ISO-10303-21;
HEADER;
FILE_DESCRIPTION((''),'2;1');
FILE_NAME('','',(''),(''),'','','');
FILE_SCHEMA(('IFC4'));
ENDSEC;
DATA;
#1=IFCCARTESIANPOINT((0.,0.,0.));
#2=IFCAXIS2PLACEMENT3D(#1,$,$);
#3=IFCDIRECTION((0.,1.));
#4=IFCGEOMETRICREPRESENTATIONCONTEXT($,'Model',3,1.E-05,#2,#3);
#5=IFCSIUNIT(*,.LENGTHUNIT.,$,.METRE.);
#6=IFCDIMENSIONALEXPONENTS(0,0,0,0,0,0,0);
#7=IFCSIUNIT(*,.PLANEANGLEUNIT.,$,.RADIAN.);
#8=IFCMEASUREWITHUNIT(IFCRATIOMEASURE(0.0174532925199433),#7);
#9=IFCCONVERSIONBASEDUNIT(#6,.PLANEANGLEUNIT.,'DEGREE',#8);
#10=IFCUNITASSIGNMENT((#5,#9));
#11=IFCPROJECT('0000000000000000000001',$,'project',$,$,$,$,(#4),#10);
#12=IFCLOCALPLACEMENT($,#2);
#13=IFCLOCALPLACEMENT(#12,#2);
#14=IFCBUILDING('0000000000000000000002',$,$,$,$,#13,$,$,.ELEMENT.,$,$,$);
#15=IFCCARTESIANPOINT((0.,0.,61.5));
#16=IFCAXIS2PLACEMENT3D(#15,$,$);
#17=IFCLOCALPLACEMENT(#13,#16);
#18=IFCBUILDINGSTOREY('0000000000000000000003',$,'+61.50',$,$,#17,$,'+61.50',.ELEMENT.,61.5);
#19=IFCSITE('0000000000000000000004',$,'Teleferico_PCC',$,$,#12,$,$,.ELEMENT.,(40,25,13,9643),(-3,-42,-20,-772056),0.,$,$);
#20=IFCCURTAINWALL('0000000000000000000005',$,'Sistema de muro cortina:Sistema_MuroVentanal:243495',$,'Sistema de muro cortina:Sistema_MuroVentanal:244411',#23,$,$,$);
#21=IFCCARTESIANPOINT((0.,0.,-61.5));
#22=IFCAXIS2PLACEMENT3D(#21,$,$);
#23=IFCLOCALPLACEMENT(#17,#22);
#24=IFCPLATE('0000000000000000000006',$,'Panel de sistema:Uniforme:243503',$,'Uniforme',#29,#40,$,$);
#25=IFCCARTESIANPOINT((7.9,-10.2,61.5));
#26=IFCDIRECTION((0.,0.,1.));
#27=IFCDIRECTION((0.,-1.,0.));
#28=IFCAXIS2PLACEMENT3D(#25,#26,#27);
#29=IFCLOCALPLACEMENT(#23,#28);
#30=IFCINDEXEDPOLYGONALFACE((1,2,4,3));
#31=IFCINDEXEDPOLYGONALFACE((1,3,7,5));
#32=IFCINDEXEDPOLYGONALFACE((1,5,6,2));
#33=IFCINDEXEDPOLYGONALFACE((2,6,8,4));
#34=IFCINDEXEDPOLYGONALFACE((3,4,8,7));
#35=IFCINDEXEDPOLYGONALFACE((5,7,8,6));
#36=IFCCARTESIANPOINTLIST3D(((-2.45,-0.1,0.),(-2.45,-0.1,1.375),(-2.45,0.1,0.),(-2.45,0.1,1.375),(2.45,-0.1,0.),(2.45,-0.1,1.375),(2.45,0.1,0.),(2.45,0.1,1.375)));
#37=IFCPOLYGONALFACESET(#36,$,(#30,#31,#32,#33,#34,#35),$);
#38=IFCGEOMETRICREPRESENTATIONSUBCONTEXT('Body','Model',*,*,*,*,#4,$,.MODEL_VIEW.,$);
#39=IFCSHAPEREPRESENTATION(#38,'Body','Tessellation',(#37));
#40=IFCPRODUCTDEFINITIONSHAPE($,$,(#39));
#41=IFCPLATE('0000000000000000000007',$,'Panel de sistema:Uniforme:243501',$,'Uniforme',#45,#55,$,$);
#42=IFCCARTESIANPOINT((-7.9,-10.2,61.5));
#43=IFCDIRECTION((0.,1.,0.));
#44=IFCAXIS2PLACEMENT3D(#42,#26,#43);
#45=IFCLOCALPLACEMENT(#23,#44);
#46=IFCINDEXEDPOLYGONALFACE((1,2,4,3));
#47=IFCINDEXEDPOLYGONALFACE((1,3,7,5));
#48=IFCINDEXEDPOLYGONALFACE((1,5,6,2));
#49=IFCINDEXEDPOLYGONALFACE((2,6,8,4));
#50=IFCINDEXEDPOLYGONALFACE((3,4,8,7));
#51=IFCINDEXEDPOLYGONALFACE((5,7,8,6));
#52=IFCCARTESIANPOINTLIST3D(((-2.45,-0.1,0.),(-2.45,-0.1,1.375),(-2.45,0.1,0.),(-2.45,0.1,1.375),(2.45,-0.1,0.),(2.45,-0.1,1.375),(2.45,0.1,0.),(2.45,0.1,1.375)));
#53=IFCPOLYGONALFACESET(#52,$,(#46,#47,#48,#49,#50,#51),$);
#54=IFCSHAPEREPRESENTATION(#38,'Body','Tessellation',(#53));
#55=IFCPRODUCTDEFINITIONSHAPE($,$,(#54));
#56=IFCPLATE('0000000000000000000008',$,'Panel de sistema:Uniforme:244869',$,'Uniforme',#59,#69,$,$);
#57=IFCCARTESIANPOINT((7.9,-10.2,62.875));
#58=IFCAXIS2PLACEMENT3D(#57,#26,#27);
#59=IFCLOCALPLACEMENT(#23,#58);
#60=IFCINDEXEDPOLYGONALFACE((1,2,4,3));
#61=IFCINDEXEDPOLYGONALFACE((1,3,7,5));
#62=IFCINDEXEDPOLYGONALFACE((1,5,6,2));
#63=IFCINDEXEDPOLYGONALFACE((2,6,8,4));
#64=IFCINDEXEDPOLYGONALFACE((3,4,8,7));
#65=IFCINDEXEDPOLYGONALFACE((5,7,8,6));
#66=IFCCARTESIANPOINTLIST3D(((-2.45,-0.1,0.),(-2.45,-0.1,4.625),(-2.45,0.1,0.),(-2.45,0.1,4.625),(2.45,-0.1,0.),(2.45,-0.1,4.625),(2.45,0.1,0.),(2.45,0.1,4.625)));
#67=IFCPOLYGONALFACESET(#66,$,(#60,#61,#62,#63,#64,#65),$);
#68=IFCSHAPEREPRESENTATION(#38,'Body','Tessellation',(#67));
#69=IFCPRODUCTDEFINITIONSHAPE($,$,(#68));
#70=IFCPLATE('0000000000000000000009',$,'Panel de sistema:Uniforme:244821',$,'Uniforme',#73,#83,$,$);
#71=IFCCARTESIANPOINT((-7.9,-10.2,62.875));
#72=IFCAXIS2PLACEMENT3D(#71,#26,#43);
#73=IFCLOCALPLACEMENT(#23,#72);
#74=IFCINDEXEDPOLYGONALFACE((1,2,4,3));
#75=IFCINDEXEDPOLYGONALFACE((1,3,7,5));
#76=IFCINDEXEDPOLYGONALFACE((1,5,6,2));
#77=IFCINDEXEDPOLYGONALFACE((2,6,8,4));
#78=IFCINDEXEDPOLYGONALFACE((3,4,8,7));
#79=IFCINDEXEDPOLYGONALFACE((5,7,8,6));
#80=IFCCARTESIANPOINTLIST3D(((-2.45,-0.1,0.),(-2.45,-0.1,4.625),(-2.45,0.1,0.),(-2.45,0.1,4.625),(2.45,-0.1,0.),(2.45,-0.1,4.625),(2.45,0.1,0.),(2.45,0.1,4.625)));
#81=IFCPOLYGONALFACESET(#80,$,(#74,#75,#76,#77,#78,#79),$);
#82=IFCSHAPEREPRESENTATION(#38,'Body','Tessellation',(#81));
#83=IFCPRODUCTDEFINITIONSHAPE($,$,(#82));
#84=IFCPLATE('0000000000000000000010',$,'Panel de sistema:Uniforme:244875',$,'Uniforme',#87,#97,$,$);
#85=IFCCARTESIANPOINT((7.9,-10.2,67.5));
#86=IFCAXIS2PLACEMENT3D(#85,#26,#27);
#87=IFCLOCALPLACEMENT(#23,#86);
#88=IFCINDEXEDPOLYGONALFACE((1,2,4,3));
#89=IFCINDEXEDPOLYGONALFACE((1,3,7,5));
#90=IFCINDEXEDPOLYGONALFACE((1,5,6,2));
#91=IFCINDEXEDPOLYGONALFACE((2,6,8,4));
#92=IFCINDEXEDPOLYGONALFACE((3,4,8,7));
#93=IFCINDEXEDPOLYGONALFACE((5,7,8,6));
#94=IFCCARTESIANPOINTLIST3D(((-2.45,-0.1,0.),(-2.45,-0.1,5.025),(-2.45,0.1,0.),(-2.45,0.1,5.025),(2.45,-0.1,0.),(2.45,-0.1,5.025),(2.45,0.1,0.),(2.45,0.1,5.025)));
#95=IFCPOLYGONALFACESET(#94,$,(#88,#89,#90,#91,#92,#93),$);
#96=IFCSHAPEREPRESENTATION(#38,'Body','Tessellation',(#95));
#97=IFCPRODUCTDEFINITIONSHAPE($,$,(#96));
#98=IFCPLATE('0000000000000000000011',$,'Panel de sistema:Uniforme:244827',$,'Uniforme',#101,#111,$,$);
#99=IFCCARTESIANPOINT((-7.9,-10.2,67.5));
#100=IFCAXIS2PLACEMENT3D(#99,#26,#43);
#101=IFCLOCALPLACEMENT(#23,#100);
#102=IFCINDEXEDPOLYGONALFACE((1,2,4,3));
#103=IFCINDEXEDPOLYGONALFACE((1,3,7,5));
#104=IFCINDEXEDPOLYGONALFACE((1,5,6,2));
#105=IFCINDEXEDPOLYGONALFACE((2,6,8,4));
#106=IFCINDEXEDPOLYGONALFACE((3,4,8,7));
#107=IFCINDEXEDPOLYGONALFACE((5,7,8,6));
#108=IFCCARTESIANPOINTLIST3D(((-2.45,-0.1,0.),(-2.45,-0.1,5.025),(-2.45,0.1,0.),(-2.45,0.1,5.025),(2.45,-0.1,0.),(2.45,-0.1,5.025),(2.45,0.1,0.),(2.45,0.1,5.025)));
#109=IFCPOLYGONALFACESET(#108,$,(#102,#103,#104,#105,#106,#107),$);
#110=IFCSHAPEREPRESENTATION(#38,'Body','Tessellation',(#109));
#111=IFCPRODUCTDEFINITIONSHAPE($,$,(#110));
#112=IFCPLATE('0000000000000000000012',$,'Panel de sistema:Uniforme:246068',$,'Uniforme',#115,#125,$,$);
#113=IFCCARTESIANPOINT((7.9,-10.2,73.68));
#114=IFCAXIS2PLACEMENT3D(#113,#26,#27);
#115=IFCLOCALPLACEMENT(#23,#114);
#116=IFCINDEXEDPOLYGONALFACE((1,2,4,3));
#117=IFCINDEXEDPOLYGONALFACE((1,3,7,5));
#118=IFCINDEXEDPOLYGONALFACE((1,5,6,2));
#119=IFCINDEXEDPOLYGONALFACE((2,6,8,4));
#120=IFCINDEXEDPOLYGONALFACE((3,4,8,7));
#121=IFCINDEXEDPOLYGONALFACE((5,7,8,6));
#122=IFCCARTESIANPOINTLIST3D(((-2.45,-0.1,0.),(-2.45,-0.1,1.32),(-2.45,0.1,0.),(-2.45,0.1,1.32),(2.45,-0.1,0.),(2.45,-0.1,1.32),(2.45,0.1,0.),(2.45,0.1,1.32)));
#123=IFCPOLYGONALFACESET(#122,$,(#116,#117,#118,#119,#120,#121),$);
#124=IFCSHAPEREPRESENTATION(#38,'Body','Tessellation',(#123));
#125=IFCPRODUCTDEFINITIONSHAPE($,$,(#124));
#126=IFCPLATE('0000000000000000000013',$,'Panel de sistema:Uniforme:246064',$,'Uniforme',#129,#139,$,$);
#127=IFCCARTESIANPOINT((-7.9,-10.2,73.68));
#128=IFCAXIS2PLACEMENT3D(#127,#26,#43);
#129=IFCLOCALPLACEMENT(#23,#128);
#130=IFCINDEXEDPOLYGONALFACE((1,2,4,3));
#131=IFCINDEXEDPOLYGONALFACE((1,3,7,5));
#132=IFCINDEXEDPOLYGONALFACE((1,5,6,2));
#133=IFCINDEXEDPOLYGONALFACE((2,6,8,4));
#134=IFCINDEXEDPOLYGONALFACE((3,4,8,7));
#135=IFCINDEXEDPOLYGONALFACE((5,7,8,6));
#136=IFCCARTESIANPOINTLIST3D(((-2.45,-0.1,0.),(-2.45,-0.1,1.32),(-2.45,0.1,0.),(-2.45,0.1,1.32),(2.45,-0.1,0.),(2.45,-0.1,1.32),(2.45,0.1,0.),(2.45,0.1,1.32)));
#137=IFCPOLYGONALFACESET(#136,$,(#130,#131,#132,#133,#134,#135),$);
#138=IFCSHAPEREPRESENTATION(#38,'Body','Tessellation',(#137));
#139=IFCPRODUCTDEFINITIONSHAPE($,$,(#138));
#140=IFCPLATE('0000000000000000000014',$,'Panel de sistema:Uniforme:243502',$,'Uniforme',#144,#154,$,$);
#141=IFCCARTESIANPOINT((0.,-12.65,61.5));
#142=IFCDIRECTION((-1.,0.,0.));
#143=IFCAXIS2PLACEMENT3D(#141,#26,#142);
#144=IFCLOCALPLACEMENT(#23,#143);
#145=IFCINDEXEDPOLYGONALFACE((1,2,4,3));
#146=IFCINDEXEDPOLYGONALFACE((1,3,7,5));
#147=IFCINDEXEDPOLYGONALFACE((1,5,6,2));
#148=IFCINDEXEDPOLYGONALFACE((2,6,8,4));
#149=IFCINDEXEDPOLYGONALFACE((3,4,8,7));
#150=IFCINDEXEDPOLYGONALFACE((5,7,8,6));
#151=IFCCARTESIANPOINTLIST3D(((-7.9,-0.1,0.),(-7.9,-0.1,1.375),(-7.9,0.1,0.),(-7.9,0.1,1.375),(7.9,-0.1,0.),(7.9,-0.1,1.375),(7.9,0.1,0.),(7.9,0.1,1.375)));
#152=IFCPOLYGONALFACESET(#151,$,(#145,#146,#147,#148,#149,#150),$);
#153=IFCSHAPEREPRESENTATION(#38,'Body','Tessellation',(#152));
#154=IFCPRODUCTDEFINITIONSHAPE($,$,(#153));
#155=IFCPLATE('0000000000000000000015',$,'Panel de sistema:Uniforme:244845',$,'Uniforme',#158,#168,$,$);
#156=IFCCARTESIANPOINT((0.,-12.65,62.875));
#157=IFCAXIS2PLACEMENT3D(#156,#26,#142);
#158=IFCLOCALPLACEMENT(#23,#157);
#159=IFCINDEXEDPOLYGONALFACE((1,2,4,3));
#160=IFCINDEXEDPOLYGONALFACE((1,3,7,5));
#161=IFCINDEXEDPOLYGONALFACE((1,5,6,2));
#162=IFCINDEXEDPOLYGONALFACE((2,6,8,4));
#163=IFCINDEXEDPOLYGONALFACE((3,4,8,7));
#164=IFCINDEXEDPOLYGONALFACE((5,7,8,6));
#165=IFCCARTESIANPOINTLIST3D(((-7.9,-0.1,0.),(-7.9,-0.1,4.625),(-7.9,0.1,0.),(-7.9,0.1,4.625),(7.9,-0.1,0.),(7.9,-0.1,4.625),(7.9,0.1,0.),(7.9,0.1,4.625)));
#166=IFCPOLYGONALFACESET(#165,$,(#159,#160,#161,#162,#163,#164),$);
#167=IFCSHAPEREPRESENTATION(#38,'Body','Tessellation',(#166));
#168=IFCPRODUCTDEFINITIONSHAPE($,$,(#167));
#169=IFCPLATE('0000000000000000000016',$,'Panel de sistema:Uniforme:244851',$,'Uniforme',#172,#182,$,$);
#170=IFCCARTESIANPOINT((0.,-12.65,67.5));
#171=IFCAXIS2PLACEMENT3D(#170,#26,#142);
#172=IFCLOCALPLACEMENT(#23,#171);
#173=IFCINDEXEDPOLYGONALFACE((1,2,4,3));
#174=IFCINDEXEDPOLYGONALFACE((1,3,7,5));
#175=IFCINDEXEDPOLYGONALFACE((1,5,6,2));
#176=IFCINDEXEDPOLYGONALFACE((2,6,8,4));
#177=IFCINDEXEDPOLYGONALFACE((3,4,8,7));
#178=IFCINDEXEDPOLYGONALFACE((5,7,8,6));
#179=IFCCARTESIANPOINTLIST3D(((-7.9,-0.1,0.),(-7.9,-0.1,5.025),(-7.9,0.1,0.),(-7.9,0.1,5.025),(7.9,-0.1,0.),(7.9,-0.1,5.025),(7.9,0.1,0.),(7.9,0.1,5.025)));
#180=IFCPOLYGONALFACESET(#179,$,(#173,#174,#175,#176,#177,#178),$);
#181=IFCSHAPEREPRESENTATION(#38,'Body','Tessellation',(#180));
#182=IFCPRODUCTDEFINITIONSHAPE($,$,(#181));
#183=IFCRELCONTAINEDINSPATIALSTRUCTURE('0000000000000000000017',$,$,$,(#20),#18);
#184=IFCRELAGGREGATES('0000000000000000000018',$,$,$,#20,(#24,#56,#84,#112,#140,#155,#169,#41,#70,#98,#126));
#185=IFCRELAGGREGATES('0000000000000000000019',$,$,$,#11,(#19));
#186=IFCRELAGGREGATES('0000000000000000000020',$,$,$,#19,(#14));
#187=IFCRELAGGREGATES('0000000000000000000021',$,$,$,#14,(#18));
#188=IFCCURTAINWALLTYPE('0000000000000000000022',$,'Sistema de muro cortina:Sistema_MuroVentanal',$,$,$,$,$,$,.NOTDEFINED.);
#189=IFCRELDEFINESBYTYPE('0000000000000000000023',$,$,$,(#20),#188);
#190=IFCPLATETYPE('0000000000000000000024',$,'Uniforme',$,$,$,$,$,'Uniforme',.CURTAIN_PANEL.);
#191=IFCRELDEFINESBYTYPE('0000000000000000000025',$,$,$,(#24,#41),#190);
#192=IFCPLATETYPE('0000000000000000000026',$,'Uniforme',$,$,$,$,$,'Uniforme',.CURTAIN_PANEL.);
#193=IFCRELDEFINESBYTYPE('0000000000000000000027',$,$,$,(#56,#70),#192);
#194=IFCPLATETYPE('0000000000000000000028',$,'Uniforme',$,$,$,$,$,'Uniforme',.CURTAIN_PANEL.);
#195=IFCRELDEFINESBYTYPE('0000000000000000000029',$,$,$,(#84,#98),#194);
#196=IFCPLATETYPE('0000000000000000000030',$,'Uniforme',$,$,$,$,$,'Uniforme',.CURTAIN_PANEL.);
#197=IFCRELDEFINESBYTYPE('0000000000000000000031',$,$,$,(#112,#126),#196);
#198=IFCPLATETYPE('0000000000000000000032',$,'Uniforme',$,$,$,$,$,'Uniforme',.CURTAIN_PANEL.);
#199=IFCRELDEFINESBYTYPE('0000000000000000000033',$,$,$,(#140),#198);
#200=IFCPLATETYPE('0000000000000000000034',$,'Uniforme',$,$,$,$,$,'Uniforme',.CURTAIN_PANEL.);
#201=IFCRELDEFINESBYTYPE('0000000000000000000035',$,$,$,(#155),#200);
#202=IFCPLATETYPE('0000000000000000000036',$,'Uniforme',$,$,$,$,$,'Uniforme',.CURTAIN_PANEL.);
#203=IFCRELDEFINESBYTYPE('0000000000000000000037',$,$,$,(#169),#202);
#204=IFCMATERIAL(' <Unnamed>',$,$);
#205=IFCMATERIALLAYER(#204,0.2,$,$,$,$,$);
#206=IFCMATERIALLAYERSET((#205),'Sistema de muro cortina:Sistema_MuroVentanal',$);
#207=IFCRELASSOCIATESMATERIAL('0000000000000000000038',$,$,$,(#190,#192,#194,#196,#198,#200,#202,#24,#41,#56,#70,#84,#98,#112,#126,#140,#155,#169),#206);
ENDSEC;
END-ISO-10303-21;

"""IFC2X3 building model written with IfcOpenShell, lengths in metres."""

from ifc_helpers import new_model, entity, si_unit, converted_unit, direction, frame, origin, origin_2d_with_axis, place, context, subcontext, project, spatial, rectangle, extrude, source, transform, mapped, material, layer, layer_set, layer_usage, type_object, type_shapes, element, aggregate, save


model = new_model("IFC2X3")

# Units and contexts
model_context = context("Model", 3, precision=1e-05, world=origin(), true_north=direction((0.0, 1.0)))
body_context = subcontext(model_context, "Body", "Model", "MODEL_VIEW")
ifc_project = project(units=[si_unit("LENGTHUNIT", "METRE"), converted_unit("PLANEANGLEUNIT", "DEGREE", entity("IfcRatioMeasure", 0.0174532925199433), si_unit("PLANEANGLEUNIT", "RADIAN"), dimensions=[0, 0, 0, 0, 0, 0, 0])], contexts=[model_context])

# Site, building, storey
site_placement = place(None, origin())
site = spatial("IfcSite", under=ifc_project, at=site_placement, Name="Teleferico_PCC", CompositionType="ELEMENT", RefLatitude=(40, 25, 13, 9643), RefLongitude=(-3, -42, -20, -772056), RefElevation=0.0)
building_placement = place(site_placement, origin())
building = spatial("IfcBuilding", under=site, at=building_placement, CompositionType="ELEMENT")
storey_placement = place(building_placement, frame((0.0, 0.0, 61.5)))
storey = spatial("IfcBuildingStorey", under=building, at=storey_placement, Name="+61.50", LongName="+61.50", CompositionType="ELEMENT", Elevation=61.5)

# Curtain wall, plates
curtain_wall_type = type_object("IfcCurtainWallType", Name="Sistema de muro cortina:Sistema_MuroVentanal", PredefinedType="NOTDEFINED")
curtain_wall_placement = place(storey_placement, frame((0.0, 0.0, -61.5)))
curtain_wall = element("IfcCurtainWall", 1, at=curtain_wall_placement, inside=storey, type_object=curtain_wall_type, Name="Sistema de muro cortina:Sistema_MuroVentanal:243495", ObjectType="Sistema de muro cortina:Sistema_MuroVentanal:244411")
ifc_material = material(Name=" <Unnamed>")
ifc_layer_1 = layer(ifc_material, 0.2)
ifc_layer_set_1 = layer_set([ifc_layer_1], Name="Sistema de muro cortina:Sistema_MuroVentanal")
ifc_layer_usage_1 = layer_usage(ifc_layer_set_1, "AXIS3", "POSITIVE", 0.0)
plate_type_1 = type_object("IfcPlateType", Name="Uniforme", ElementType="Uniforme", PredefinedType="CURTAIN_PANEL", material=ifc_layer_set_1)
shared_shape_1 = source(origin(), body_context, "Body", "SweptSolid", [
    extrude(rectangle(XDim=0.2, YDim=4.9, at=origin_2d_with_axis()), frame((0.0, 0.0, 0.0), z_axis=(0.0, 0.0, 1.0), x_axis=(0.0, 1.0, 0.0)), (0.0, 0.0, 1.0), 1.375),
])
type_shapes(plate_type_1, [shared_shape_1])
plate_1_placement = place(curtain_wall_placement, frame((7.9, -10.2, 61.5), z_axis=(0.0, 0.0, 1.0), x_axis=(0.0, -1.0, 0.0)))
plate_1 = element("IfcPlate", 2, at=plate_1_placement, type_object=plate_type_1, material=ifc_layer_usage_1, Name="Panel de sistema:Uniforme:243503", ObjectType="Uniforme", context=body_context, shape_type="MappedRepresentation", body=[
    mapped(shared_shape_1, transform((0.0, 0.0, 0.0), scale=1.0)),
])
ifc_layer_usage_2 = layer_usage(ifc_layer_set_1, "AXIS3", "POSITIVE", 0.0)
plate_2_placement = place(curtain_wall_placement, frame((-7.9, -10.2, 61.5), z_axis=(0.0, 0.0, 1.0), x_axis=(0.0, 1.0, 0.0)))
plate_2 = element("IfcPlate", 3, at=plate_2_placement, type_object=plate_type_1, material=ifc_layer_usage_2, Name="Panel de sistema:Uniforme:243501", ObjectType="Uniforme", context=body_context, shape_type="MappedRepresentation", body=[
    mapped(shared_shape_1, transform((0.0, 0.0, 0.0), scale=1.0)),
])
ifc_layer_usage_3 = layer_usage(ifc_layer_set_1, "AXIS3", "POSITIVE", 0.0)
plate_type_2 = type_object("IfcPlateType", Name="Uniforme", ElementType="Uniforme", PredefinedType="CURTAIN_PANEL", material=ifc_layer_set_1)
shared_shape_2 = source(origin(), body_context, "Body", "SweptSolid", [
    extrude(rectangle(XDim=0.2, YDim=4.9, at=origin_2d_with_axis()), frame((0.0, 0.0, 0.0), z_axis=(0.0, 0.0, 1.0), x_axis=(0.0, 1.0, 0.0)), (0.0, 0.0, 1.0), 4.625),
])
type_shapes(plate_type_2, [shared_shape_2])
plate_3_placement = place(curtain_wall_placement, frame((7.9, -10.2, 62.875), z_axis=(0.0, 0.0, 1.0), x_axis=(0.0, -1.0, 0.0)))
plate_3 = element("IfcPlate", 4, at=plate_3_placement, type_object=plate_type_2, material=ifc_layer_usage_3, Name="Panel de sistema:Uniforme:244869", ObjectType="Uniforme", context=body_context, shape_type="MappedRepresentation", body=[
    mapped(shared_shape_2, transform((0.0, 0.0, 0.0), scale=1.0)),
])
ifc_layer_usage_4 = layer_usage(ifc_layer_set_1, "AXIS3", "POSITIVE", 0.0)
plate_4_placement = place(curtain_wall_placement, frame((-7.9, -10.2, 62.875), z_axis=(0.0, 0.0, 1.0), x_axis=(0.0, 1.0, 0.0)))
plate_4 = element("IfcPlate", 5, at=plate_4_placement, type_object=plate_type_2, material=ifc_layer_usage_4, Name="Panel de sistema:Uniforme:244821", ObjectType="Uniforme", context=body_context, shape_type="MappedRepresentation", body=[
    mapped(shared_shape_2, transform((0.0, 0.0, 0.0), scale=1.0)),
])
ifc_layer_usage_5 = layer_usage(ifc_layer_set_1, "AXIS3", "POSITIVE", 0.0)
plate_type_3 = type_object("IfcPlateType", Name="Uniforme", ElementType="Uniforme", PredefinedType="CURTAIN_PANEL", material=ifc_layer_set_1)
shared_shape_3 = source(origin(), body_context, "Body", "SweptSolid", [
    extrude(rectangle(XDim=0.2, YDim=4.9, at=origin_2d_with_axis()), frame((0.0, 0.0, 0.0), z_axis=(0.0, 0.0, 1.0), x_axis=(0.0, 1.0, 0.0)), (0.0, 0.0, 1.0), 5.025),
])
type_shapes(plate_type_3, [shared_shape_3])
plate_5_placement = place(curtain_wall_placement, frame((7.9, -10.2, 67.5), z_axis=(0.0, 0.0, 1.0), x_axis=(0.0, -1.0, 0.0)))
plate_5 = element("IfcPlate", 6, at=plate_5_placement, type_object=plate_type_3, material=ifc_layer_usage_5, Name="Panel de sistema:Uniforme:244875", ObjectType="Uniforme", context=body_context, shape_type="MappedRepresentation", body=[
    mapped(shared_shape_3, transform((0.0, 0.0, 0.0), scale=1.0)),
])
ifc_layer_usage_6 = layer_usage(ifc_layer_set_1, "AXIS3", "POSITIVE", 0.0)
plate_6_placement = place(curtain_wall_placement, frame((-7.9, -10.2, 67.5), z_axis=(0.0, 0.0, 1.0), x_axis=(0.0, 1.0, 0.0)))
plate_6 = element("IfcPlate", 7, at=plate_6_placement, type_object=plate_type_3, material=ifc_layer_usage_6, Name="Panel de sistema:Uniforme:244827", ObjectType="Uniforme", context=body_context, shape_type="MappedRepresentation", body=[
    mapped(shared_shape_3, transform((0.0, 0.0, 0.0), scale=1.0)),
])
ifc_layer_usage_7 = layer_usage(ifc_layer_set_1, "AXIS3", "POSITIVE", 0.0)
plate_type_4 = type_object("IfcPlateType", Name="Uniforme", ElementType="Uniforme", PredefinedType="CURTAIN_PANEL", material=ifc_layer_set_1)
shared_shape_4 = source(origin(), body_context, "Body", "SweptSolid", [
    extrude(rectangle(XDim=0.2, YDim=4.9, at=origin_2d_with_axis()), frame((0.0, 0.0, 0.0), z_axis=(0.0, 0.0, 1.0), x_axis=(0.0, 1.0, 0.0)), (0.0, 0.0, 1.0), 1.32),
])
type_shapes(plate_type_4, [shared_shape_4])
plate_7_placement = place(curtain_wall_placement, frame((7.9, -10.2, 73.68), z_axis=(0.0, 0.0, 1.0), x_axis=(0.0, -1.0, 0.0)))
plate_7 = element("IfcPlate", 8, at=plate_7_placement, type_object=plate_type_4, material=ifc_layer_usage_7, Name="Panel de sistema:Uniforme:246068", ObjectType="Uniforme", context=body_context, shape_type="MappedRepresentation", body=[
    mapped(shared_shape_4, transform((0.0, 0.0, 0.0), scale=1.0)),
])
ifc_layer_usage_8 = layer_usage(ifc_layer_set_1, "AXIS3", "POSITIVE", 0.0)
plate_8_placement = place(curtain_wall_placement, frame((-7.9, -10.2, 73.68), z_axis=(0.0, 0.0, 1.0), x_axis=(0.0, 1.0, 0.0)))
plate_8 = element("IfcPlate", 9, at=plate_8_placement, type_object=plate_type_4, material=ifc_layer_usage_8, Name="Panel de sistema:Uniforme:246064", ObjectType="Uniforme", context=body_context, shape_type="MappedRepresentation", body=[
    mapped(shared_shape_4, transform((0.0, 0.0, 0.0), scale=1.0)),
])
ifc_layer_usage_9 = layer_usage(ifc_layer_set_1, "AXIS3", "POSITIVE", 0.0)
plate_type_5 = type_object("IfcPlateType", Name="Uniforme", ElementType="Uniforme", PredefinedType="CURTAIN_PANEL", material=ifc_layer_set_1)
shared_shape_5 = source(origin(), body_context, "Body", "SweptSolid", [
    extrude(rectangle(XDim=0.2, YDim=15.8, at=origin_2d_with_axis()), frame((0.0, 0.0, 0.0), z_axis=(0.0, 0.0, 1.0), x_axis=(0.0, 1.0, 0.0)), (0.0, 0.0, 1.0), 1.375),
])
type_shapes(plate_type_5, [shared_shape_5])
plate_9_placement = place(curtain_wall_placement, frame((0.0, -12.65, 61.5), z_axis=(0.0, 0.0, 1.0), x_axis=(-1.0, 0.0, 0.0)))
plate_9 = element("IfcPlate", 10, at=plate_9_placement, type_object=plate_type_5, material=ifc_layer_usage_9, Name="Panel de sistema:Uniforme:243502", ObjectType="Uniforme", context=body_context, shape_type="MappedRepresentation", body=[
    mapped(shared_shape_5, transform((0.0, 0.0, 0.0), scale=1.0)),
])
ifc_layer_usage_10 = layer_usage(ifc_layer_set_1, "AXIS3", "POSITIVE", 0.0)
plate_type_6 = type_object("IfcPlateType", Name="Uniforme", ElementType="Uniforme", PredefinedType="CURTAIN_PANEL", material=ifc_layer_set_1)
shared_shape_6 = source(origin(), body_context, "Body", "SweptSolid", [
    extrude(rectangle(XDim=0.2, YDim=15.8, at=origin_2d_with_axis()), frame((0.0, 0.0, 0.0), z_axis=(0.0, 0.0, 1.0), x_axis=(0.0, 1.0, 0.0)), (0.0, 0.0, 1.0), 4.625),
])
type_shapes(plate_type_6, [shared_shape_6])
plate_10_placement = place(curtain_wall_placement, frame((0.0, -12.65, 62.875), z_axis=(0.0, 0.0, 1.0), x_axis=(-1.0, 0.0, 0.0)))
plate_10 = element("IfcPlate", 11, at=plate_10_placement, type_object=plate_type_6, material=ifc_layer_usage_10, Name="Panel de sistema:Uniforme:244845", ObjectType="Uniforme", context=body_context, shape_type="MappedRepresentation", body=[
    mapped(shared_shape_6, transform((0.0, 0.0, 0.0), scale=1.0)),
])
ifc_layer_usage_11 = layer_usage(ifc_layer_set_1, "AXIS3", "POSITIVE", 0.0)
plate_type_7 = type_object("IfcPlateType", Name="Uniforme", ElementType="Uniforme", PredefinedType="CURTAIN_PANEL", material=ifc_layer_set_1)
shared_shape_7 = source(origin(), body_context, "Body", "SweptSolid", [
    extrude(rectangle(XDim=0.2, YDim=15.8, at=origin_2d_with_axis()), frame((0.0, 0.0, 0.0), z_axis=(0.0, 0.0, 1.0), x_axis=(0.0, 1.0, 0.0)), (0.0, 0.0, 1.0), 5.025),
])
type_shapes(plate_type_7, [shared_shape_7])
plate_11_placement = place(curtain_wall_placement, frame((0.0, -12.65, 67.5), z_axis=(0.0, 0.0, 1.0), x_axis=(-1.0, 0.0, 0.0)))
plate_11 = element("IfcPlate", 12, at=plate_11_placement, type_object=plate_type_7, material=ifc_layer_usage_11, Name="Panel de sistema:Uniforme:244851", ObjectType="Uniforme", context=body_context, shape_type="MappedRepresentation", body=[
    mapped(shared_shape_7, transform((0.0, 0.0, 0.0), scale=1.0)),
])
aggregate(curtain_wall, [plate_1, plate_3, plate_5, plate_7, plate_9, plate_10, plate_11, plate_2, plate_4, plate_6, plate_8])

save(model, "model.ifc")
